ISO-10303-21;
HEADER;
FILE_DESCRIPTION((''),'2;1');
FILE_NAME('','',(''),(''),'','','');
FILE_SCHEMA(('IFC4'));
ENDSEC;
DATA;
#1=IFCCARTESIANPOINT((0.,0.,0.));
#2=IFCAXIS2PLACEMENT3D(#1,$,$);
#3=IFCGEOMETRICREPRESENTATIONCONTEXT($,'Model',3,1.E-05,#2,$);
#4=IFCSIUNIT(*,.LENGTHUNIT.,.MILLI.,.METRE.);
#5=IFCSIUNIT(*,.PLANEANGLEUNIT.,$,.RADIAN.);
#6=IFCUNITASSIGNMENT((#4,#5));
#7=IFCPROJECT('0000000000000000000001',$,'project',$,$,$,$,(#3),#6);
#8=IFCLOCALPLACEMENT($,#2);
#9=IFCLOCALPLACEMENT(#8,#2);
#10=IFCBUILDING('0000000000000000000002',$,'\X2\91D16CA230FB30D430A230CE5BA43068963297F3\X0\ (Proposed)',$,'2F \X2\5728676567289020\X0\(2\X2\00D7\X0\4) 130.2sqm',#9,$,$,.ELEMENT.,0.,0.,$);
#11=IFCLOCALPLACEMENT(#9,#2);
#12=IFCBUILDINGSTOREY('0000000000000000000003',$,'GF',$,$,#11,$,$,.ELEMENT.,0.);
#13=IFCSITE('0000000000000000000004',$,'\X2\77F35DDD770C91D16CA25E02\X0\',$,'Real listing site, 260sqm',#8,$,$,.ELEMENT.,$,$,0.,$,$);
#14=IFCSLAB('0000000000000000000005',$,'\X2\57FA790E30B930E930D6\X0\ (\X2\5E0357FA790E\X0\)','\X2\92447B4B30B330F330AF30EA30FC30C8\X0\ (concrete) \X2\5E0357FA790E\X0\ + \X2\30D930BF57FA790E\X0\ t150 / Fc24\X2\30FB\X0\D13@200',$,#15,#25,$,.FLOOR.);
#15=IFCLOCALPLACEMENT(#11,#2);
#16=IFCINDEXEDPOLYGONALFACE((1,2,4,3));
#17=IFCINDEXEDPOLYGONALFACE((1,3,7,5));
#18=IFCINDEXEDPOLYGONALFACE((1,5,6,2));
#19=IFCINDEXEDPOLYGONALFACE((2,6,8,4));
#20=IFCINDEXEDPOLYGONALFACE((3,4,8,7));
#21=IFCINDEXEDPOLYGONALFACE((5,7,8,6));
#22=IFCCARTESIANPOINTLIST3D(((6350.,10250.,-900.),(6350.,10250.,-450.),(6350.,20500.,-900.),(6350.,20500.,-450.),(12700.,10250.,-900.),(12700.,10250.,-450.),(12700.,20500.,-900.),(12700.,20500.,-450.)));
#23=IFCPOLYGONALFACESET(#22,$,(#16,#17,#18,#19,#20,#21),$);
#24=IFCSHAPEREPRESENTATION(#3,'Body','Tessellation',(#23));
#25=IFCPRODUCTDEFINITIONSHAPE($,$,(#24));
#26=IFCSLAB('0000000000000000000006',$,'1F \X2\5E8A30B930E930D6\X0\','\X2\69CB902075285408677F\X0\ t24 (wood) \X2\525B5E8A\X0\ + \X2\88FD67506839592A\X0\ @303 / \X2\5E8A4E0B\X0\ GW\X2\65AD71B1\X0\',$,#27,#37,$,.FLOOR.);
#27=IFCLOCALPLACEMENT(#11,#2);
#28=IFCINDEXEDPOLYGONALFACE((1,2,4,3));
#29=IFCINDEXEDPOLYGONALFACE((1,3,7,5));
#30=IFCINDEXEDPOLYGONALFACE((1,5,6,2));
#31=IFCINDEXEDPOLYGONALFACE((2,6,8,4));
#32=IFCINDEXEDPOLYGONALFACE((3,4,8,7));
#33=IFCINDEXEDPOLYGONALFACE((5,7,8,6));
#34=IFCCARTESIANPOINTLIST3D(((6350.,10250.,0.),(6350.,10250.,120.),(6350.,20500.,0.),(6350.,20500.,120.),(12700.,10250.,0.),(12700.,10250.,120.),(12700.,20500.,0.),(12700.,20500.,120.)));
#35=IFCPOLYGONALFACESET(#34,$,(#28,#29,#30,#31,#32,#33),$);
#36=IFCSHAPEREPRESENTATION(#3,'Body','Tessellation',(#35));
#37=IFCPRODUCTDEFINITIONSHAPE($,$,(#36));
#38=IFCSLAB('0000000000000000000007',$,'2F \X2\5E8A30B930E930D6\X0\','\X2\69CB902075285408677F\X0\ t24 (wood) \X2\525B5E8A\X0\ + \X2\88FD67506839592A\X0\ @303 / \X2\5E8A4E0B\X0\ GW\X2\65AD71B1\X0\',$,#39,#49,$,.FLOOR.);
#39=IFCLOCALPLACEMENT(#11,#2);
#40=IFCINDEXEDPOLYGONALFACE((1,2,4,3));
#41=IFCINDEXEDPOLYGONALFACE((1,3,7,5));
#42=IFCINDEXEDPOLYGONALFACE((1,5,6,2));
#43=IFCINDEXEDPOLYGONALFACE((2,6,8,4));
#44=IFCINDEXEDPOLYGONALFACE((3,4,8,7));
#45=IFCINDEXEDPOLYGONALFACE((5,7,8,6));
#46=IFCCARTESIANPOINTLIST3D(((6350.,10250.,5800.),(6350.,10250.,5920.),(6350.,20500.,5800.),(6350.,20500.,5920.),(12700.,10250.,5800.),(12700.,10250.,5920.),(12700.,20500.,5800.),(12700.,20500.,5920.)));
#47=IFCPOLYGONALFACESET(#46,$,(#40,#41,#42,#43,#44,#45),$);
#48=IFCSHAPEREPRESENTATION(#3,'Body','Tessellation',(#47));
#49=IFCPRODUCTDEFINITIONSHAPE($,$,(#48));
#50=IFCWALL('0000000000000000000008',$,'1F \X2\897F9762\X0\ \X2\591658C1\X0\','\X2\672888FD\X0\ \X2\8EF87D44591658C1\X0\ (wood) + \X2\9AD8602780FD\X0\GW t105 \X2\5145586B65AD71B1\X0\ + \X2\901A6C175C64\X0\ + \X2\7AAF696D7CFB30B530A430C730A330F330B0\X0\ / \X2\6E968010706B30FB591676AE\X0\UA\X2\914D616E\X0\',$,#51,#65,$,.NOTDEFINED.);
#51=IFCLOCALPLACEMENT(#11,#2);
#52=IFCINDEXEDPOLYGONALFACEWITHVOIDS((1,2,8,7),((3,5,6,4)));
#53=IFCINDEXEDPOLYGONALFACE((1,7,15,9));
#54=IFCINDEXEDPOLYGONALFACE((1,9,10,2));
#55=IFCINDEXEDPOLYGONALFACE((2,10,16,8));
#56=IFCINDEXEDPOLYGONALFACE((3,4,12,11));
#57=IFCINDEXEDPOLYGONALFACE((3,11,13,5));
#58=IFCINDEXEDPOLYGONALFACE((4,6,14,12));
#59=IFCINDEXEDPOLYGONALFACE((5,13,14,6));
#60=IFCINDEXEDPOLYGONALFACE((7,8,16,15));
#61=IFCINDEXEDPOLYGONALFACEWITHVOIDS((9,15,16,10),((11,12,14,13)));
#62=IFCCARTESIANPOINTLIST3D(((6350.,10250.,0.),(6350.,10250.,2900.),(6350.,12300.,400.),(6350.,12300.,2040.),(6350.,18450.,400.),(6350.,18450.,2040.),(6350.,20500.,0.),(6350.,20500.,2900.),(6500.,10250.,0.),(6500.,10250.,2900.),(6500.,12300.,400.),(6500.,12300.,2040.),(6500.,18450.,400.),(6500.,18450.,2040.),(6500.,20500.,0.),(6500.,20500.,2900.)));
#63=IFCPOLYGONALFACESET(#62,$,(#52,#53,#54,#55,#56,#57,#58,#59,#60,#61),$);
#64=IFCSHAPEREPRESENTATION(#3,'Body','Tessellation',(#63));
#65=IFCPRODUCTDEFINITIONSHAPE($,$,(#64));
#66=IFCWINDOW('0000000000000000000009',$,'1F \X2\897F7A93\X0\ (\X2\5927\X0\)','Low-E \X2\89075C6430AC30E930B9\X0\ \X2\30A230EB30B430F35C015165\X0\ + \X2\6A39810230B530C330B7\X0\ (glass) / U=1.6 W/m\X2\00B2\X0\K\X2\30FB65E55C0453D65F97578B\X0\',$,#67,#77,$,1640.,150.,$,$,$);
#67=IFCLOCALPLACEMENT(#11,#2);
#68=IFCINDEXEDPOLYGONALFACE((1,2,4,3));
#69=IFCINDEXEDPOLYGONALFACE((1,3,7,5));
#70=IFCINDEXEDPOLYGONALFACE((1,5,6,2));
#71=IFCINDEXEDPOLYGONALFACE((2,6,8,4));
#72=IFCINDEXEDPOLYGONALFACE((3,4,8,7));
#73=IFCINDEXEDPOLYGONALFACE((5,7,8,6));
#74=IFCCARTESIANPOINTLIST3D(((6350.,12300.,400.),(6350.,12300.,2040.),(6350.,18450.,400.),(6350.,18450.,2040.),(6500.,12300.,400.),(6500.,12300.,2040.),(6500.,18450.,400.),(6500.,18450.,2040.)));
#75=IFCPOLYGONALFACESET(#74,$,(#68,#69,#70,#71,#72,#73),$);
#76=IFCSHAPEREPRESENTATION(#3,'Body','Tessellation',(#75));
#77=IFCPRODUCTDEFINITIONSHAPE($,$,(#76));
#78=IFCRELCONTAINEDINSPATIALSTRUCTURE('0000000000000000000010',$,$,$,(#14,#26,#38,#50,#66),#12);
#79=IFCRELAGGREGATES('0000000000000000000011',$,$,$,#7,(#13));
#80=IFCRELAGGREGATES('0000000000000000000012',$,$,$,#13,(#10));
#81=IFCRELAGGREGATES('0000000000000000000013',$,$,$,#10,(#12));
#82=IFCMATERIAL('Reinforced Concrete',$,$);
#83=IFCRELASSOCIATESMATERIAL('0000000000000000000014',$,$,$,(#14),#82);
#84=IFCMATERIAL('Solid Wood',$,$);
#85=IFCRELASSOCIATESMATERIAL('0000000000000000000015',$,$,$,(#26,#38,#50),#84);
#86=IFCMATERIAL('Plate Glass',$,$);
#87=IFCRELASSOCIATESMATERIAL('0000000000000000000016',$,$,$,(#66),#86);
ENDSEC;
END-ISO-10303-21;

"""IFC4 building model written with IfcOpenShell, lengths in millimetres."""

from ifc_helpers import new_model, si_unit, frame, frame_2d, origin, place, context, project, spatial, rectangle, extrude, material, element, fill, save


model = new_model("IFC4")

# Units and contexts
model_context = context("Model", 3, precision=1e-05, world=origin())
ifc_project = project(units=[si_unit("LENGTHUNIT", "METRE", prefix="MILLI"), si_unit("PLANEANGLEUNIT", "RADIAN")], contexts=[model_context])

# Site, building, storey
site_placement = place(None, origin())
site = spatial("IfcSite", under=ifc_project, at=site_placement, Name="石川県金沢市", ObjectType="Real listing site, 260sqm", CompositionType="ELEMENT", RefElevation=0.0)
building_placement = place(site_placement, origin())
building = spatial("IfcBuilding", under=site, at=building_placement, Name="金沢・ピアノ室と防音 (Proposed)", ObjectType="2F 在来木造(2×4) 130.2sqm", CompositionType="ELEMENT", ElevationOfRefHeight=0.0, ElevationOfTerrain=0.0)
storey_placement = place(building_placement, origin())
storey = spatial("IfcBuildingStorey", under=building, at=storey_placement, Name="GF", CompositionType="ELEMENT", Elevation=0.0)

# Shared definitions
ifc_material_1 = material(Name="Solid Wood")

# Slabs
ifc_material_2 = material(Name="Reinforced Concrete")
slab_1_placement = place(storey_placement, frame((3175.0, 5125.0, -450.0)))
element("IfcSlab", 1, at=slab_1_placement, inside=storey, material=ifc_material_2, Name="基礎スラブ (布基礎)", Description="鉄筋コンクリート (concrete) 布基礎 + ベタ基礎 t150 / Fc24・D13@200", PredefinedType="FLOOR", context=model_context, shape_type="SweptSolid", body=[
    extrude(rectangle(XDim=6350.0, YDim=10250.0, at=frame_2d((3175.0, 5125.0))), frame((3175.0, 5125.0, -450.0)), (0.0, 0.0, 1.0), 450.0),
])
slab_2_placement = place(storey_placement, frame((3175.0, 5125.0, 0.0)))
element("IfcSlab", 2, at=slab_2_placement, inside=storey, material=ifc_material_1, Name="1F 床スラブ", Description="構造用合板 t24 (wood) 剛床 + 製材根太 @303 / 床下 GW断熱", PredefinedType="FLOOR", context=model_context, shape_type="SweptSolid", body=[
    extrude(rectangle(XDim=6350.0, YDim=10250.0, at=frame_2d((3175.0, 5125.0))), frame((3175.0, 5125.0, 0.0)), (0.0, 0.0, 1.0), 120.0),
])
slab_3_placement = place(storey_placement, frame((3175.0, 5125.0, 2900.0)))
element("IfcSlab", 3, at=slab_3_placement, inside=storey, material=ifc_material_1, Name="2F 床スラブ", Description="構造用合板 t24 (wood) 剛床 + 製材根太 @303 / 床下 GW断熱", PredefinedType="FLOOR", context=model_context, shape_type="SweptSolid", body=[
    extrude(rectangle(XDim=6350.0, YDim=10250.0, at=frame_2d((3175.0, 5125.0))), frame((3175.0, 5125.0, 2900.0)), (0.0, 0.0, 1.0), 120.0),
])

# Shared definitions
ifc_material_3 = material(Name="Plate Glass")

# Wall, opening, window
wall_1_placement = place(storey_placement, frame((3175.0, 5125.0, 0.0)))
wall_1 = element("IfcWall", 4, at=wall_1_placement, inside=storey, material=ifc_material_1, Name="1F 西面 外壁", Description="木製 軸組外壁 (wood) + 高性能GW t105 充填断熱 + 通気層 + 窯業系サイディング / 準耐火・外皮UA配慮", PredefinedType="NOTDEFINED", context=model_context, shape_type="SweptSolid", body=[
    extrude(rectangle(XDim=150.0, YDim=10250.0, at=frame_2d((75.0, 5125.0))), frame((3175.0, 5125.0, 0.0)), (0.0, 0.0, 1.0), 2900.0),
])
opening_1_placement = place(storey_placement, frame((3175.0, 6150.0, 200.0)))
opening_1 = element("IfcOpeningElement", 5, at=opening_1_placement, cuts=wall_1, PredefinedType="NOTDEFINED", context=model_context, shape_type="SweptSolid", body=[
    extrude(rectangle(XDim=150.0, YDim=6150.0, at=frame_2d((75.0, 3075.0))), frame((3175.0, 6150.0, 200.0)), (0.0, 0.0, 1.0), 1640.0),
])
window_1_placement = place(storey_placement, frame((3175.0, 6150.0, 200.0)))
window_1 = element("IfcWindow", 6, at=window_1_placement, inside=storey, material=ifc_material_3, Name="1F 西窓 (大)", Description="Low-E 複層ガラス アルゴン封入 + 樹脂サッシ (glass) / U=1.6 W/m²K・日射取得型", OverallHeight=1640.0, OverallWidth=150.0, context=model_context, shape_type="SweptSolid", body=[
    extrude(rectangle(XDim=150.0, YDim=6150.0, at=frame_2d((75.0, 3075.0))), frame((3175.0, 6150.0, 200.0)), (0.0, 0.0, 1.0), 1640.0),
])
fill(opening_1, window_1)

save(model, "model.ifc")
